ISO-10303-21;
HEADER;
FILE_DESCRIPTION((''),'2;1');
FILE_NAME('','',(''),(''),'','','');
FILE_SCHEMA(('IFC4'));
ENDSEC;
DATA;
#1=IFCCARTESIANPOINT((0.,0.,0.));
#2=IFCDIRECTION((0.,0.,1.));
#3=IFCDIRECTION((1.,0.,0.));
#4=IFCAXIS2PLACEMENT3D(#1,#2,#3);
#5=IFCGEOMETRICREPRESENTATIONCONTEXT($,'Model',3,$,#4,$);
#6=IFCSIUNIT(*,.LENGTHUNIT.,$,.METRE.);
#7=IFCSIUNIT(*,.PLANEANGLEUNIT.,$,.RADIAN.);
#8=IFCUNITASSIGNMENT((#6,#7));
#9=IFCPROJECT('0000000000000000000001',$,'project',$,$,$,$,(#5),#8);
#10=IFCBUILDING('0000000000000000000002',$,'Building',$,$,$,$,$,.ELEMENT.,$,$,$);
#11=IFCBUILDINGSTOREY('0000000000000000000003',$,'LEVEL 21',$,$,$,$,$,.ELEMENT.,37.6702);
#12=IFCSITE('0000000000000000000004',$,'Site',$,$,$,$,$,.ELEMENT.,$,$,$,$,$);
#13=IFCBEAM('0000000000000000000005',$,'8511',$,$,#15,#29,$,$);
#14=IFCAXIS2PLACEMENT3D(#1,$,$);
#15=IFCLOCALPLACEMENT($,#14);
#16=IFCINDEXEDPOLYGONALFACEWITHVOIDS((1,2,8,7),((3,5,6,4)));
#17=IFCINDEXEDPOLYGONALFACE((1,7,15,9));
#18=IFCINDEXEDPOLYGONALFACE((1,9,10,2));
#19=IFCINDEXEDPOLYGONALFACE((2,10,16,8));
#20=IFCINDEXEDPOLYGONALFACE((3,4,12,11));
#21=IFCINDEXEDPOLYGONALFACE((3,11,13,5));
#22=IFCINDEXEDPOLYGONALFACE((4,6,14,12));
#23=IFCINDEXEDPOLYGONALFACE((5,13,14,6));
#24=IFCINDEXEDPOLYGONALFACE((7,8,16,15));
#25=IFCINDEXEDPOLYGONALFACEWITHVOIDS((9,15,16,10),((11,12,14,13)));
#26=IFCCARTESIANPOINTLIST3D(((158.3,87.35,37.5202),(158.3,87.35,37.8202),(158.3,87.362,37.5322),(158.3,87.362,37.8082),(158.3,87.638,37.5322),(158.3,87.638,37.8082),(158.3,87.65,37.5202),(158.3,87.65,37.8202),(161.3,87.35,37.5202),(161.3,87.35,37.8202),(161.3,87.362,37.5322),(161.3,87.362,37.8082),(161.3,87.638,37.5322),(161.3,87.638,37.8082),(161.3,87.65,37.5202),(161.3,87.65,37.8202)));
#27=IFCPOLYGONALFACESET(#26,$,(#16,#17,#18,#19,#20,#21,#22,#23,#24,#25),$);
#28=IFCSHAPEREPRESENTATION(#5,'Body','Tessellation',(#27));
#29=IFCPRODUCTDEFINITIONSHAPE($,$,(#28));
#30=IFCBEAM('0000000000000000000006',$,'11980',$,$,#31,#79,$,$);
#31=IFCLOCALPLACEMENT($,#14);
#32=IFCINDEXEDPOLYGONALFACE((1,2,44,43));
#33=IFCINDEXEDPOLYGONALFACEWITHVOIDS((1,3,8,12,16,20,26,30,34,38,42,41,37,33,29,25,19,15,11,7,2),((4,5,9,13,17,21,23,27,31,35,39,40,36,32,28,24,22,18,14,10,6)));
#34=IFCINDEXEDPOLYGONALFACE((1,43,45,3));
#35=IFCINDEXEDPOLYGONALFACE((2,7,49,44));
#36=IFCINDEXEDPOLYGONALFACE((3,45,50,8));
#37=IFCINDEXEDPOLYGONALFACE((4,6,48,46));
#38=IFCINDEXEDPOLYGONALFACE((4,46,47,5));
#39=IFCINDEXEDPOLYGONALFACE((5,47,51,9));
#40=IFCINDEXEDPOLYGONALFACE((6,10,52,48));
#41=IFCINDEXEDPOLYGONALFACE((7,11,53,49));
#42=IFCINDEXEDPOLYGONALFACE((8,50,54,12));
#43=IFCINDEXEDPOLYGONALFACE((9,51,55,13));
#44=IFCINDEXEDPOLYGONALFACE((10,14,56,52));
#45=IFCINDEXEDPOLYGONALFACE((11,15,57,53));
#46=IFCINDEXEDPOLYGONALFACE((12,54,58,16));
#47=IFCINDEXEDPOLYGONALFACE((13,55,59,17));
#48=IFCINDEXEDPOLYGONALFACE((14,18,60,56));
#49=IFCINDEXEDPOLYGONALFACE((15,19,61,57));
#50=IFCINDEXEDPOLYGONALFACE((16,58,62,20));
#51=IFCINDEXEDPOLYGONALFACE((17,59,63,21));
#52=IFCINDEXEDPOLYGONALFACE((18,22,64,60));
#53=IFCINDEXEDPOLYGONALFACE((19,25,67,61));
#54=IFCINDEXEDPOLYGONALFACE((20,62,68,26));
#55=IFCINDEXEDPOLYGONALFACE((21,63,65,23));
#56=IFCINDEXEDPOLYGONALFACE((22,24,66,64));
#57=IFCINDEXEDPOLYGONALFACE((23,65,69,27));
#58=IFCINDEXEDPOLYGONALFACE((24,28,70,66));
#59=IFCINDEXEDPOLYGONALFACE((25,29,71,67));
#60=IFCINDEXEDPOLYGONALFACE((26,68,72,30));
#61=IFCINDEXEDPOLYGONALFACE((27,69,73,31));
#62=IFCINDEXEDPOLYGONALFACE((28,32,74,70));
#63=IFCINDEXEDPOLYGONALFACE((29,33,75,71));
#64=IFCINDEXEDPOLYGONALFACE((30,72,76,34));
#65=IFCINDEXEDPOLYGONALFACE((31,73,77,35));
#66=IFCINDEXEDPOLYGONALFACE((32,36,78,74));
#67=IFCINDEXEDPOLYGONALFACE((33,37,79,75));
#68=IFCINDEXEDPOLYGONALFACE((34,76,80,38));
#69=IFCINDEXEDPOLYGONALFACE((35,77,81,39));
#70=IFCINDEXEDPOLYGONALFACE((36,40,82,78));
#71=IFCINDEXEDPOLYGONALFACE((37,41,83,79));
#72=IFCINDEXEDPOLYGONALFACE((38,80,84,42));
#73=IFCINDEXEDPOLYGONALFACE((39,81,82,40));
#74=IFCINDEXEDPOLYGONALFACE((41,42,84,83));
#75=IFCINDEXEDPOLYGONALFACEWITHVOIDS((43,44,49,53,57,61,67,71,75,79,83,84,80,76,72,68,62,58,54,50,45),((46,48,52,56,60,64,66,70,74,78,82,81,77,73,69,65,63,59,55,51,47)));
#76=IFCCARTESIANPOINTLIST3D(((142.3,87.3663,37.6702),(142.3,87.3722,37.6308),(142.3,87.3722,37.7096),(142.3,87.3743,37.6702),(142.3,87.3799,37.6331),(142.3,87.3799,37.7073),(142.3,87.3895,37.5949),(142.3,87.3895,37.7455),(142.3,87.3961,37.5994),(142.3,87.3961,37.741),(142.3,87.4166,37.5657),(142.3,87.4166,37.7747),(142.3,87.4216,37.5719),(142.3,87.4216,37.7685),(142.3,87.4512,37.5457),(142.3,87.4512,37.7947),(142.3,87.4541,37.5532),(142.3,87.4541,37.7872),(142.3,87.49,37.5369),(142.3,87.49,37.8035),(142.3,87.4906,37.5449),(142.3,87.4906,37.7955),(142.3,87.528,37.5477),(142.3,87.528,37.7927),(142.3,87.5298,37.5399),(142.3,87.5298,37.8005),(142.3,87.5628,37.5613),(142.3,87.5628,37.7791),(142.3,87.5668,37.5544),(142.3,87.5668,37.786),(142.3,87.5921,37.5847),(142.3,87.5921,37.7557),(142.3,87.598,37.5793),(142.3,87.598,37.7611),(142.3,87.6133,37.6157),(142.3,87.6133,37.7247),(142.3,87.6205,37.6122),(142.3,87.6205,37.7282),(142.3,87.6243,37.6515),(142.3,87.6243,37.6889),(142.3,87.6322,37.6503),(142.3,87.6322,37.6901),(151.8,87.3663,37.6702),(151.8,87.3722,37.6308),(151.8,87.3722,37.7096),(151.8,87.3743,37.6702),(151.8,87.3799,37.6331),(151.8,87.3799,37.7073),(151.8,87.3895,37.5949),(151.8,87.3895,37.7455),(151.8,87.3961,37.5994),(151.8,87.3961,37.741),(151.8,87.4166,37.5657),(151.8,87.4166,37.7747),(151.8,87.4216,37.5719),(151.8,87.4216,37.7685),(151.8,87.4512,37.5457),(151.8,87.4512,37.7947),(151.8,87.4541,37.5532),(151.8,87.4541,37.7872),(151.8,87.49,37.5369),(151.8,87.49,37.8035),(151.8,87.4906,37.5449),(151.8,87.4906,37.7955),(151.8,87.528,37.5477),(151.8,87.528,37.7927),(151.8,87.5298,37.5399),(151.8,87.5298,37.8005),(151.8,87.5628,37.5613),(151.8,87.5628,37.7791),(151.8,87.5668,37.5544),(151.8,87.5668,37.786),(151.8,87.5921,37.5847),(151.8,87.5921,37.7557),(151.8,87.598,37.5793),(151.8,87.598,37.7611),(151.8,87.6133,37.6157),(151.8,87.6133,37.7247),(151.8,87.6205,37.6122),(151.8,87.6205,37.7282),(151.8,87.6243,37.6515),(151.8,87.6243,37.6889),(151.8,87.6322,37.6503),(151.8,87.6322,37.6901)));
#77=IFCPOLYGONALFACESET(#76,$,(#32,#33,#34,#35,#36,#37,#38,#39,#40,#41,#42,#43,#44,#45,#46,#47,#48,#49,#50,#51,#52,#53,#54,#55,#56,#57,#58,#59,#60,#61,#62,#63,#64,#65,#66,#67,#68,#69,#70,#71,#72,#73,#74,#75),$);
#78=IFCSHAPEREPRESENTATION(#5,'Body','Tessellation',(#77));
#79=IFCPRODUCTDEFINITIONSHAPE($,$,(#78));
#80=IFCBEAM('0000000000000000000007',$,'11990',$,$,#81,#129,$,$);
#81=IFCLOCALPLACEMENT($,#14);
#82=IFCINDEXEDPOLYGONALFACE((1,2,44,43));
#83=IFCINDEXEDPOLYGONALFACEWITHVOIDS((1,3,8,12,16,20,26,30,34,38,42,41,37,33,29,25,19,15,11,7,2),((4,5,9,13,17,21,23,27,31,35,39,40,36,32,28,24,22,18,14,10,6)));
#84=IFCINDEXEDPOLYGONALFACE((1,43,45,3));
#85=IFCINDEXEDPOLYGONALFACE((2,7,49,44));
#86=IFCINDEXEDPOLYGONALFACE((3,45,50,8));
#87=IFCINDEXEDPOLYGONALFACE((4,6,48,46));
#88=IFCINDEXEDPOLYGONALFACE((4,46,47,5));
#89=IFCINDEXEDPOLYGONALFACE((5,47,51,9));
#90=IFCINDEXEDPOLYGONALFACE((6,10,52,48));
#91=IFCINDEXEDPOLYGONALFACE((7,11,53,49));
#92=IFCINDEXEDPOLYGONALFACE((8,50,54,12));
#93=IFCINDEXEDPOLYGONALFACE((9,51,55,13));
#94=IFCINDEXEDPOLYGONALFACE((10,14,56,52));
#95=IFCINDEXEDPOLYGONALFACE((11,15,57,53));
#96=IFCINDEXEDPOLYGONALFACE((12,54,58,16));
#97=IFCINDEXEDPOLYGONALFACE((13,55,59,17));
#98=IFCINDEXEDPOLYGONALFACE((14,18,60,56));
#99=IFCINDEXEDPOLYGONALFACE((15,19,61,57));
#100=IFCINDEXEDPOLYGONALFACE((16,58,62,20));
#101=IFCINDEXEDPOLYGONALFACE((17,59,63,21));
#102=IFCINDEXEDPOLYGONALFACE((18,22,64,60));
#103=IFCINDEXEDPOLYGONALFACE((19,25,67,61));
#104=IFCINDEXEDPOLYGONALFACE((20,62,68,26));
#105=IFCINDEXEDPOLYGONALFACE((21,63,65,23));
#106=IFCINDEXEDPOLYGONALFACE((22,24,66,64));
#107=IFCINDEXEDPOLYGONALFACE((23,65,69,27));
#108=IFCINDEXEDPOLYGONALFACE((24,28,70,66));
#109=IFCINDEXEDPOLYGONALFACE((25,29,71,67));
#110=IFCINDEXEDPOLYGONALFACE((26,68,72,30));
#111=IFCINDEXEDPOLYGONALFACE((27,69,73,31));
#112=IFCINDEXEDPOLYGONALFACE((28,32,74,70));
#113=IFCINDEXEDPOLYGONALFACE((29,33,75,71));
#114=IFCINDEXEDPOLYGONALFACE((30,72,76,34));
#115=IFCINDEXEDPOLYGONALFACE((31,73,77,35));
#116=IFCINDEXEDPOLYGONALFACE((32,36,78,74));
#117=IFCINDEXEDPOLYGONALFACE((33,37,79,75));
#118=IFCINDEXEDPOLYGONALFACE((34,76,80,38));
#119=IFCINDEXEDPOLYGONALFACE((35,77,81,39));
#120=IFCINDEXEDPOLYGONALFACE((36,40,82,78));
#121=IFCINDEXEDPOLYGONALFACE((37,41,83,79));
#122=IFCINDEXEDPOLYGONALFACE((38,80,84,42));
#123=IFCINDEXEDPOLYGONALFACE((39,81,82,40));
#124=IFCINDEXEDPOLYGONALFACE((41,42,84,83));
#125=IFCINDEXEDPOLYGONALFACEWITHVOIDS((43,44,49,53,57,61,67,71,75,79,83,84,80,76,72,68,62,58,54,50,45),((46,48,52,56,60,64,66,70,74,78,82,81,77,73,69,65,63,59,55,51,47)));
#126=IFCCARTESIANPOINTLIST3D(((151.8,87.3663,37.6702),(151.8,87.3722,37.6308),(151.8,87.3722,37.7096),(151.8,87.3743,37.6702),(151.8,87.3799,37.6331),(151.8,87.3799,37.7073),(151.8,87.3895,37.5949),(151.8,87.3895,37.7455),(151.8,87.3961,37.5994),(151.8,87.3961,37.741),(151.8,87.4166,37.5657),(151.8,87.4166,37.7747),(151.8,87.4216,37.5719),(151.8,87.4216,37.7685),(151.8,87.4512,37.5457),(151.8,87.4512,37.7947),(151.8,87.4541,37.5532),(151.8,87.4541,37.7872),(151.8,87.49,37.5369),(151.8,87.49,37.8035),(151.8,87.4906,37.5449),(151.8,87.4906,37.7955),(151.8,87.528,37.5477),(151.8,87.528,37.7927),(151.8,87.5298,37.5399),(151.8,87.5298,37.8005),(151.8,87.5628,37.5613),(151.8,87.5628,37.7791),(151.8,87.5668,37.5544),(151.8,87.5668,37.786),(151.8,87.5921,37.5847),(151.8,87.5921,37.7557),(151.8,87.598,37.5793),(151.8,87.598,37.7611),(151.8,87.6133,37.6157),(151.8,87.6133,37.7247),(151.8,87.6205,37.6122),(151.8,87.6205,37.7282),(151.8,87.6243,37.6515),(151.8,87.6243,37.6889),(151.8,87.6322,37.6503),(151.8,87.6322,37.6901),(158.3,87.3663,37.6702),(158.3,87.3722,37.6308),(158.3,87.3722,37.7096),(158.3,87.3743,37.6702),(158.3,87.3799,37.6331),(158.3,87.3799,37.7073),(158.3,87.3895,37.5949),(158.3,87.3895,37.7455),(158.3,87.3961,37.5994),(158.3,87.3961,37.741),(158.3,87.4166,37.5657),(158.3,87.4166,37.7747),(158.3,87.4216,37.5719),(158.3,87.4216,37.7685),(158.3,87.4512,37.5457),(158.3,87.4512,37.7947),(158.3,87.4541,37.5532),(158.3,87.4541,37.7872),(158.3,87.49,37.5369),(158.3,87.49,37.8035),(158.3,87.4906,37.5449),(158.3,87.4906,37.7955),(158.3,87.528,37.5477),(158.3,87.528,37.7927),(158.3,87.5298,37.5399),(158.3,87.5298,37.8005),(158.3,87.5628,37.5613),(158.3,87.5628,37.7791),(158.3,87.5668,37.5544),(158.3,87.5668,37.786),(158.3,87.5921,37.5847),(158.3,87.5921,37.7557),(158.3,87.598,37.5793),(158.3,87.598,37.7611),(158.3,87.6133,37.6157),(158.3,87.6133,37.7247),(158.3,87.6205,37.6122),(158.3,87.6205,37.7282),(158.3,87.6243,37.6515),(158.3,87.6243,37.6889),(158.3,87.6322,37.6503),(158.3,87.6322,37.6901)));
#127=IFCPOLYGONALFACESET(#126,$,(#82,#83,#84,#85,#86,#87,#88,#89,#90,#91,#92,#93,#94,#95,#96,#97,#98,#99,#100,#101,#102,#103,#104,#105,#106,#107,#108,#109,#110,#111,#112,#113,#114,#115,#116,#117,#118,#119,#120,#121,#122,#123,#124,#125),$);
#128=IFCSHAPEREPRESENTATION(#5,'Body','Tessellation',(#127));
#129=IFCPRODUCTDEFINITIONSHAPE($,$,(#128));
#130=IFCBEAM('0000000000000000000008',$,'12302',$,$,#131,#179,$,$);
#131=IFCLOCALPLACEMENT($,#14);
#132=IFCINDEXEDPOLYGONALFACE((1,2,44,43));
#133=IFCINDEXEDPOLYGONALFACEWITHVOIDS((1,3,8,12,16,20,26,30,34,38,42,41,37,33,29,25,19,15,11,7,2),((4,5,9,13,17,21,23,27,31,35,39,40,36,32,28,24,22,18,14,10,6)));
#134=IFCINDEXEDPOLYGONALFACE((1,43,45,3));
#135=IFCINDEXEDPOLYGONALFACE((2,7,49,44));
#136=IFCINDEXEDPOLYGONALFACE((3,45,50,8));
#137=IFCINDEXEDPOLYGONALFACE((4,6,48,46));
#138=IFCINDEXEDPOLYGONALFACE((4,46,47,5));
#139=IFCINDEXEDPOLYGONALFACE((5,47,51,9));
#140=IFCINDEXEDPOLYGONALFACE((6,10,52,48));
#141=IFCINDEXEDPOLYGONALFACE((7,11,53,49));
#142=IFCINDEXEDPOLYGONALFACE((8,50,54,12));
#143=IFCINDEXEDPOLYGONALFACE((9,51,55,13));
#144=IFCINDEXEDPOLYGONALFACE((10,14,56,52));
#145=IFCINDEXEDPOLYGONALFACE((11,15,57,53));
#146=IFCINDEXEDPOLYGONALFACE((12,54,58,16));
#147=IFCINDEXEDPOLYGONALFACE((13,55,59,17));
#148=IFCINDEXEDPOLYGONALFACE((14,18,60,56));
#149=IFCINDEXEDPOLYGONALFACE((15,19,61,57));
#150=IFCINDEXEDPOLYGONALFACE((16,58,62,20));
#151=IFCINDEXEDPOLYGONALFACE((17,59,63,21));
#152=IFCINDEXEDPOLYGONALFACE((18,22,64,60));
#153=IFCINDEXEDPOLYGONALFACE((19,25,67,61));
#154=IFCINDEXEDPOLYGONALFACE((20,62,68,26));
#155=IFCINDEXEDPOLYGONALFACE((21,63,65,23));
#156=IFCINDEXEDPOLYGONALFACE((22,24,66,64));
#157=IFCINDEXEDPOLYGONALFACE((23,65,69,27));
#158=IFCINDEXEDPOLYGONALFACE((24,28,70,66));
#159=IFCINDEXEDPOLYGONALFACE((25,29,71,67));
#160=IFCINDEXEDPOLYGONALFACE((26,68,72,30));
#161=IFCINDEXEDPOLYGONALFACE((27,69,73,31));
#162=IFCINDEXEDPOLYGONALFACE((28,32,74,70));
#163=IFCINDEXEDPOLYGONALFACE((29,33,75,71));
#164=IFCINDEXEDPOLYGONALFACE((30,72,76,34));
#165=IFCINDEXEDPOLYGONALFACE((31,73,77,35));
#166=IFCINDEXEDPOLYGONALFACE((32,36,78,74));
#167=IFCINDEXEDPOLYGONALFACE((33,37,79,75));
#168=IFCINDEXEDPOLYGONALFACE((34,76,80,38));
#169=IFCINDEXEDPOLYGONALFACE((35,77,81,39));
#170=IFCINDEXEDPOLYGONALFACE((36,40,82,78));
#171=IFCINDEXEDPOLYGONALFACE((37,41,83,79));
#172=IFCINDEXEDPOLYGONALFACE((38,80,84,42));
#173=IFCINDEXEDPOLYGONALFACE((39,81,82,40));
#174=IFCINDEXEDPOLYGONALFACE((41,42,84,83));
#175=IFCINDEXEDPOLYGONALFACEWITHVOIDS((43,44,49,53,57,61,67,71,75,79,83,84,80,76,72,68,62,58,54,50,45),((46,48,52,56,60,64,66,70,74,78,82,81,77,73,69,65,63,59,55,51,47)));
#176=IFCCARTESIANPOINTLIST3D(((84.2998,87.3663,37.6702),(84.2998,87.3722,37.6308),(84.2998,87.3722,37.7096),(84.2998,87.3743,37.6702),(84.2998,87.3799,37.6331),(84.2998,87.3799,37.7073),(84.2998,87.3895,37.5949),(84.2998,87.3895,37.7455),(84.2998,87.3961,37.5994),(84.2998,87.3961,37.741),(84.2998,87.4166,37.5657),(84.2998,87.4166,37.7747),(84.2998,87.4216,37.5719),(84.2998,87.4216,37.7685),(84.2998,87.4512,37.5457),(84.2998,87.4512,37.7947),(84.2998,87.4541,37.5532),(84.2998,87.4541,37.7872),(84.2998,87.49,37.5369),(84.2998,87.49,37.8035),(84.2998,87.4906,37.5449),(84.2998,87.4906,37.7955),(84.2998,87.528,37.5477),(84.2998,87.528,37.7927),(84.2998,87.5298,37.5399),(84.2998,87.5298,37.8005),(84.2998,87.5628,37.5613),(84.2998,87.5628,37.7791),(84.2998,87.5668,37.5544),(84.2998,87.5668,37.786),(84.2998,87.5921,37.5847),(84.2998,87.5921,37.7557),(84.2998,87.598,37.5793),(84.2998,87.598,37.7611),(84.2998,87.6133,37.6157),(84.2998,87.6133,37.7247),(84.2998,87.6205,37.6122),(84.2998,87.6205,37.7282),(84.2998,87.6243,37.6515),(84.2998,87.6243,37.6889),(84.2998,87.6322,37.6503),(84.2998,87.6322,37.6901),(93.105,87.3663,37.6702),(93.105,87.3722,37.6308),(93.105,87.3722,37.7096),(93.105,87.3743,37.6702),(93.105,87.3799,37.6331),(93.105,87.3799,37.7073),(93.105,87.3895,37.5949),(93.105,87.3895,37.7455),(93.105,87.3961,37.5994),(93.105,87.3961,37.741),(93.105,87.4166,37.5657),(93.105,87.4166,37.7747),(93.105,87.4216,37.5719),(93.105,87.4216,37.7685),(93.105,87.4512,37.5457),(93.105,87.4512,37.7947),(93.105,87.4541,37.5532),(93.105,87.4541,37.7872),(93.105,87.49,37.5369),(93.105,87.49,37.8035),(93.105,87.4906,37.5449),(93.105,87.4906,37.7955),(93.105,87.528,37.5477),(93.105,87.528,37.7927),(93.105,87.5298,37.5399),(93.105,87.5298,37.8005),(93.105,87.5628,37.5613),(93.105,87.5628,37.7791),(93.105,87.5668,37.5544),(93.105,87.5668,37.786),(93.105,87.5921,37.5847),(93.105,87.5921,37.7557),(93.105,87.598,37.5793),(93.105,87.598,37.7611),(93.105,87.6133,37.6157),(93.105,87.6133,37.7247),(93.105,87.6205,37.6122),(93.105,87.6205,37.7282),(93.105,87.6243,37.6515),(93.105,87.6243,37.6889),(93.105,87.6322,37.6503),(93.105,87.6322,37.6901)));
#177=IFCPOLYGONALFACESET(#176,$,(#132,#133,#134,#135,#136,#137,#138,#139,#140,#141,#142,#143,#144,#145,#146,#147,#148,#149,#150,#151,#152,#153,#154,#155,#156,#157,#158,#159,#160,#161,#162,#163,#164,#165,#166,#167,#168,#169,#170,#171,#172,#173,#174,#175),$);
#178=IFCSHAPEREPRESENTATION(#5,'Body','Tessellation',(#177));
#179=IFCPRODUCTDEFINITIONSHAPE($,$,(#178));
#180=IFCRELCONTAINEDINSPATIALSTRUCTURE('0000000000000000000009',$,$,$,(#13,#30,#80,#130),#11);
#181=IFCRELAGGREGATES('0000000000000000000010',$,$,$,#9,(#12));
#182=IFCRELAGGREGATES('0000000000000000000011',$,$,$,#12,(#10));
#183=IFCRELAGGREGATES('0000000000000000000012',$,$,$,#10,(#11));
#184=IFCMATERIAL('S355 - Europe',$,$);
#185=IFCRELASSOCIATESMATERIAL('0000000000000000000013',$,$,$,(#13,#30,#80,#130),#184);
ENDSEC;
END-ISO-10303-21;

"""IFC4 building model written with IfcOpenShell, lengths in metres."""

from ifc_helpers import new_model, si_unit, frame, origin_with_axes, origin_2d_with_axis, place, context, project, spatial, hollow_rectangle, hollow_circle, extrude, material, material_profile, profile_set, profile_usage, element, save


model = new_model("IFC4")

# Units and contexts
model_context = context("Model", 3, world=origin_with_axes())
ifc_project = project(units=[si_unit("LENGTHUNIT", "METRE"), si_unit("PLANEANGLEUNIT", "RADIAN")], contexts=[model_context])

# Site, building, storey
site = spatial("IfcSite", under=ifc_project, Name="Site", CompositionType="ELEMENT")
building = spatial("IfcBuilding", under=site, Name="Building", CompositionType="ELEMENT")
storey = spatial("IfcBuildingStorey", under=building, Name="LEVEL 21", CompositionType="ELEMENT", Elevation=37.6702)

# Beams
ifc_material = material(Name="S355 - Europe")
ifc_material_profile_1 = material_profile(ifc_material, hollow_rectangle(XDim=0.3, YDim=0.3, WallThickness=0.012, at=origin_2d_with_axis()))
ifc_profile_set_1 = profile_set([ifc_material_profile_1])
ifc_profile_usage_1 = profile_usage(ifc_profile_set_1, cardinal=10)
beam_1_placement = place(None, frame((158.3, 87.5, 37.6702), z_axis=(1.0, 0.0, 0.0), x_axis=(0.0, 1.0, 0.0)))
element("IfcBeam", 1, at=beam_1_placement, inside=storey, material=ifc_profile_usage_1, Name="8511", context=model_context, shape_type="SweptSolid", body=[
    extrude(hollow_rectangle(XDim=0.3, YDim=0.3, WallThickness=0.012, at=origin_2d_with_axis()), origin_with_axes(), (0.0, 0.0, 1.0), 3.0),
])
ifc_material_profile_2 = material_profile(ifc_material, hollow_circle(Radius=0.1337, WallThickness=0.008, at=origin_2d_with_axis()))
ifc_profile_set_2 = profile_set([ifc_material_profile_2])
ifc_profile_usage_2 = profile_usage(ifc_profile_set_2, cardinal=10)
beam_2_placement = place(None, frame((151.8, 87.5, 37.6702), z_axis=(-1.0, 0.0, 0.0), x_axis=(0.0, -1.0, 0.0)))
element("IfcBeam", 2, at=beam_2_placement, inside=storey, material=ifc_profile_usage_2, Name="11980", context=model_context, shape_type="SweptSolid", body=[
    extrude(hollow_circle(Radius=0.1337, WallThickness=0.008, at=origin_2d_with_axis()), origin_with_axes(), (0.0, 0.0, 1.0), 9.5),
])
ifc_material_profile_3 = material_profile(ifc_material, hollow_circle(Radius=0.1337, WallThickness=0.008, at=origin_2d_with_axis()))
ifc_profile_set_3 = profile_set([ifc_material_profile_3])
ifc_profile_usage_3 = profile_usage(ifc_profile_set_3, cardinal=10)
beam_3_placement = place(None, frame((158.3, 87.5, 37.6702), z_axis=(-1.0, 0.0, 0.0), x_axis=(0.0, -1.0, 0.0)))
element("IfcBeam", 3, at=beam_3_placement, inside=storey, material=ifc_profile_usage_3, Name="11990", context=model_context, shape_type="SweptSolid", body=[
    extrude(hollow_circle(Radius=0.1337, WallThickness=0.008, at=origin_2d_with_axis()), origin_with_axes(), (0.0, 0.0, 1.0), 6.5),
])
ifc_material_profile_4 = material_profile(ifc_material, hollow_circle(Radius=0.1337, WallThickness=0.008, at=origin_2d_with_axis()))
ifc_profile_set_4 = profile_set([ifc_material_profile_4])
ifc_profile_usage_4 = profile_usage(ifc_profile_set_4, cardinal=10)
beam_4_placement = place(None, frame((93.105, 87.5, 37.6702), z_axis=(-1.0, 0.0, 0.0), x_axis=(0.0, -1.0, 0.0)))
element("IfcBeam", 4, at=beam_4_placement, inside=storey, material=ifc_profile_usage_4, Name="12302", context=model_context, shape_type="SweptSolid", body=[
    extrude(hollow_circle(Radius=0.1337, WallThickness=0.008, at=origin_2d_with_axis()), origin_with_axes(), (0.0, 0.0, 1.0), 8.8052),
])

save(model, "model.ifc")
